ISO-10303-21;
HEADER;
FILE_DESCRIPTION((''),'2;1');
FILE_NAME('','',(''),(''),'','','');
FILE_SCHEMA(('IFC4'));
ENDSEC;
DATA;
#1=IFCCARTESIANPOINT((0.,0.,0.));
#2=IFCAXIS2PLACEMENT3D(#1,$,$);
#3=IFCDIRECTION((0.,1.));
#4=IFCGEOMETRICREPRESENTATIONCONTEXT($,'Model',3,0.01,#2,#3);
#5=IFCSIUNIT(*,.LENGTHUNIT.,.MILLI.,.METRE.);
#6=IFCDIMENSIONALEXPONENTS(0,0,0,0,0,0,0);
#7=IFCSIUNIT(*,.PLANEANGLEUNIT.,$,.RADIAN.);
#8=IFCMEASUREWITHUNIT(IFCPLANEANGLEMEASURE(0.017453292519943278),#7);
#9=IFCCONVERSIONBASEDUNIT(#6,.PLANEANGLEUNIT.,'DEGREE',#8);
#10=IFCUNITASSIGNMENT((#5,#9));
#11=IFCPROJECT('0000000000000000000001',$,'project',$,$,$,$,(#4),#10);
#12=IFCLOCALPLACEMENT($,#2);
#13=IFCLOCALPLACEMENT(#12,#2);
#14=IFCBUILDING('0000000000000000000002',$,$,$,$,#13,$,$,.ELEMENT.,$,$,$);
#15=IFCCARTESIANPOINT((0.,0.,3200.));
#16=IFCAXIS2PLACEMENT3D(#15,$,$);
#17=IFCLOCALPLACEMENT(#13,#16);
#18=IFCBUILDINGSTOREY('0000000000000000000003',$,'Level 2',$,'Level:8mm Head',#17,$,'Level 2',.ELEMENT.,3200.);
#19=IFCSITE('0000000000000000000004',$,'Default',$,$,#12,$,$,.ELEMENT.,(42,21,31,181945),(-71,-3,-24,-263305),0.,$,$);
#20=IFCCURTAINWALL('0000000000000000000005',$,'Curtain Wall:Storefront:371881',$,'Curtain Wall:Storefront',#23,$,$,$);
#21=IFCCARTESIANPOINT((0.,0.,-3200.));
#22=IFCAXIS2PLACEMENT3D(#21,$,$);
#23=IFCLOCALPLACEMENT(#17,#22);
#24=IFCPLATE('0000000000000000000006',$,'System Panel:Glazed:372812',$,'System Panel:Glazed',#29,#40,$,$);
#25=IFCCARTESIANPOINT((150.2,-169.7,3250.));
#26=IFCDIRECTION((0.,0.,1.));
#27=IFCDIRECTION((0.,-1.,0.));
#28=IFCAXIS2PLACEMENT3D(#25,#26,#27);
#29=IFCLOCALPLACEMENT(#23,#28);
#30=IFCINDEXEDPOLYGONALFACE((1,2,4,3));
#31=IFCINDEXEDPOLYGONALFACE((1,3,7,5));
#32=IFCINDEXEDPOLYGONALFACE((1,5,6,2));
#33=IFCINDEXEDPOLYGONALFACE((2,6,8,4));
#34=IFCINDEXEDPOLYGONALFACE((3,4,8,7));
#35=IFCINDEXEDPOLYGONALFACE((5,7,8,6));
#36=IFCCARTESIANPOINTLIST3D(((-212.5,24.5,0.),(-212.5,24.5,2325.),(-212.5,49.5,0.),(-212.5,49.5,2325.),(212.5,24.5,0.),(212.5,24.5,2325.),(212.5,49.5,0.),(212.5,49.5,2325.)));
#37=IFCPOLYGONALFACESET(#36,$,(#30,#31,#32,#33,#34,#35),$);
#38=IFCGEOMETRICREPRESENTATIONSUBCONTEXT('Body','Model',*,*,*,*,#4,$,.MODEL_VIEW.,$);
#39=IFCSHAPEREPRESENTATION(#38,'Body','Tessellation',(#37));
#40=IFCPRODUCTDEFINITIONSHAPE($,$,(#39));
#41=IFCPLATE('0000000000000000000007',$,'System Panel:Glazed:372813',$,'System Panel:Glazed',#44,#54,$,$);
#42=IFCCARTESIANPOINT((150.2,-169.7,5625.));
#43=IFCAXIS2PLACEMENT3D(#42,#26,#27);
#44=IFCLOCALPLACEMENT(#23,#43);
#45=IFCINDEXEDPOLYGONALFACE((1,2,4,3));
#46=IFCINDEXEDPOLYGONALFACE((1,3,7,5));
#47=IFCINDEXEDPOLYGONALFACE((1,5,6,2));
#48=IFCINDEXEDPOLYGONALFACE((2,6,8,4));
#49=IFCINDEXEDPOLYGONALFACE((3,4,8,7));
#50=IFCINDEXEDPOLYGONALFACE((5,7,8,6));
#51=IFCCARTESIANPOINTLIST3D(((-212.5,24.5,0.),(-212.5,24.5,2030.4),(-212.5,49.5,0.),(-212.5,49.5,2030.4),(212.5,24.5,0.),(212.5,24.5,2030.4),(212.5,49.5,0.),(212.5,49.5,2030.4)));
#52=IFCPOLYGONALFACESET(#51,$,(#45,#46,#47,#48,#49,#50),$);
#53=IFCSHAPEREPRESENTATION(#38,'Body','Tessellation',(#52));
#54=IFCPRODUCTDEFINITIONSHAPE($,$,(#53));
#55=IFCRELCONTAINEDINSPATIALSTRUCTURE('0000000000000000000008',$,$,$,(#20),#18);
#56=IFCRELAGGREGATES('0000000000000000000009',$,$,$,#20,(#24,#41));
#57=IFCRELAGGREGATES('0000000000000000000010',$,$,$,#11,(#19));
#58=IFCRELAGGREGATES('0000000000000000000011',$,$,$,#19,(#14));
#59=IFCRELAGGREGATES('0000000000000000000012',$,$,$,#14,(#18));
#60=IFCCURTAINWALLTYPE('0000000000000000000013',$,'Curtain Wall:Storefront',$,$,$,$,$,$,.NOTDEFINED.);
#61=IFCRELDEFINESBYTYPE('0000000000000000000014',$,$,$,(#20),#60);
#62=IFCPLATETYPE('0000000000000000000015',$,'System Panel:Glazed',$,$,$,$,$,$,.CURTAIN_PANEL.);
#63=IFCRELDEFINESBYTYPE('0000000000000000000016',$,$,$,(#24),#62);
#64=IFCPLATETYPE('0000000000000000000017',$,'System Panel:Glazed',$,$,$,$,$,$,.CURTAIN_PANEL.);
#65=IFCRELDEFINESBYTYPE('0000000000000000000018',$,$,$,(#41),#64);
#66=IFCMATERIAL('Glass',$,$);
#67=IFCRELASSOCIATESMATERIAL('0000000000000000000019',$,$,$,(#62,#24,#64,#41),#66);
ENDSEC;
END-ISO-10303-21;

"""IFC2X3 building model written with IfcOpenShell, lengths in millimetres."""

from ifc_helpers import new_model, entity, si_unit, converted_unit, direction, frame, origin, origin_2d_with_axis, place, context, subcontext, project, spatial, rectangle, extrude, source, transform, mapped, material, type_object, type_shapes, element, aggregate, save


model = new_model("IFC2X3")

# Units and contexts
model_context = context("Model", 3, precision=0.01, world=origin(), true_north=direction((0.0, 1.0)))
body_context = subcontext(model_context, "Body", "Model", "MODEL_VIEW")
ifc_project = project(units=[si_unit("LENGTHUNIT", "METRE", prefix="MILLI"), converted_unit("PLANEANGLEUNIT", "DEGREE", entity("IfcPlaneAngleMeasure", 0.017453292519943278), si_unit("PLANEANGLEUNIT", "RADIAN"), dimensions=[0, 0, 0, 0, 0, 0, 0])], contexts=[model_context])

# Site, building, storey
site_placement = place(None, origin())
site = spatial("IfcSite", under=ifc_project, at=site_placement, Name="Default", CompositionType="ELEMENT", RefLatitude=(42, 21, 31, 181945), RefLongitude=(-71, -3, -24, -263305), RefElevation=0.0)
building_placement = place(site_placement, origin())
building = spatial("IfcBuilding", under=site, at=building_placement, CompositionType="ELEMENT")
storey_placement = place(building_placement, frame((0.0, 0.0, 3200.0)))
storey = spatial("IfcBuildingStorey", under=building, at=storey_placement, Name="Level 2", ObjectType="Level:8mm Head", LongName="Level 2", CompositionType="ELEMENT", Elevation=3200.0)

# Curtain wall
curtain_wall_type = type_object("IfcCurtainWallType", Name="Curtain Wall:Storefront", PredefinedType="NOTDEFINED")
curtain_wall_1_placement = place(storey_placement, frame((0.0, 0.0, -3200.0)))
curtain_wall_1 = element("IfcCurtainWall", 1, at=curtain_wall_1_placement, inside=storey, type_object=curtain_wall_type, Name="Curtain Wall:Storefront:371881", ObjectType="Curtain Wall:Storefront")

# Plates
ifc_material_1 = material(Name="Glass")
plate_type_1 = type_object("IfcPlateType", Name="System Panel:Glazed", PredefinedType="CURTAIN_PANEL", material=ifc_material_1)
shared_shape_1 = source(origin(), body_context, "Body", "SweptSolid", [
    extrude(rectangle(XDim=25.0, YDim=425.0, at=origin_2d_with_axis()), frame((0.0, 37.0, 0.0), z_axis=(0.0, 0.0, 1.0), x_axis=(0.0, 1.0, 0.0)), (0.0, 0.0, 1.0), 2325.0),
])
type_shapes(plate_type_1, [shared_shape_1])
plate_1_placement = place(curtain_wall_1_placement, frame((150.2, -169.7, 3250.0), z_axis=(0.0, 0.0, 1.0), x_axis=(0.0, -1.0, 0.0)))
plate_1 = element("IfcPlate", 2, at=plate_1_placement, type_object=plate_type_1, material=ifc_material_1, Name="System Panel:Glazed:372812", ObjectType="System Panel:Glazed", context=body_context, shape_type="MappedRepresentation", body=[
    mapped(shared_shape_1, transform((0.0, 0.0, 0.0), scale=1.0)),
])
plate_type_2 = type_object("IfcPlateType", Name="System Panel:Glazed", PredefinedType="CURTAIN_PANEL", material=ifc_material_1)
shared_shape_2 = source(origin(), body_context, "Body", "SweptSolid", [
    extrude(rectangle(XDim=25.0, YDim=425.0, at=origin_2d_with_axis()), frame((0.0, 37.0, 0.0), z_axis=(0.0, 0.0, 1.0), x_axis=(0.0, 1.0, 0.0)), (0.0, 0.0, 1.0), 2030.4),
])
type_shapes(plate_type_2, [shared_shape_2])
plate_2_placement = place(curtain_wall_1_placement, frame((150.2, -169.7, 5625.0), z_axis=(0.0, 0.0, 1.0), x_axis=(0.0, -1.0, 0.0)))
plate_2 = element("IfcPlate", 3, at=plate_2_placement, type_object=plate_type_2, material=ifc_material_1, Name="System Panel:Glazed:372813", ObjectType="System Panel:Glazed", context=body_context, shape_type="MappedRepresentation", body=[
    mapped(shared_shape_2, transform((0.0, 0.0, 0.0), scale=1.0)),
])
aggregate(curtain_wall_1, [plate_1, plate_2])

save(model, "model.ifc")
